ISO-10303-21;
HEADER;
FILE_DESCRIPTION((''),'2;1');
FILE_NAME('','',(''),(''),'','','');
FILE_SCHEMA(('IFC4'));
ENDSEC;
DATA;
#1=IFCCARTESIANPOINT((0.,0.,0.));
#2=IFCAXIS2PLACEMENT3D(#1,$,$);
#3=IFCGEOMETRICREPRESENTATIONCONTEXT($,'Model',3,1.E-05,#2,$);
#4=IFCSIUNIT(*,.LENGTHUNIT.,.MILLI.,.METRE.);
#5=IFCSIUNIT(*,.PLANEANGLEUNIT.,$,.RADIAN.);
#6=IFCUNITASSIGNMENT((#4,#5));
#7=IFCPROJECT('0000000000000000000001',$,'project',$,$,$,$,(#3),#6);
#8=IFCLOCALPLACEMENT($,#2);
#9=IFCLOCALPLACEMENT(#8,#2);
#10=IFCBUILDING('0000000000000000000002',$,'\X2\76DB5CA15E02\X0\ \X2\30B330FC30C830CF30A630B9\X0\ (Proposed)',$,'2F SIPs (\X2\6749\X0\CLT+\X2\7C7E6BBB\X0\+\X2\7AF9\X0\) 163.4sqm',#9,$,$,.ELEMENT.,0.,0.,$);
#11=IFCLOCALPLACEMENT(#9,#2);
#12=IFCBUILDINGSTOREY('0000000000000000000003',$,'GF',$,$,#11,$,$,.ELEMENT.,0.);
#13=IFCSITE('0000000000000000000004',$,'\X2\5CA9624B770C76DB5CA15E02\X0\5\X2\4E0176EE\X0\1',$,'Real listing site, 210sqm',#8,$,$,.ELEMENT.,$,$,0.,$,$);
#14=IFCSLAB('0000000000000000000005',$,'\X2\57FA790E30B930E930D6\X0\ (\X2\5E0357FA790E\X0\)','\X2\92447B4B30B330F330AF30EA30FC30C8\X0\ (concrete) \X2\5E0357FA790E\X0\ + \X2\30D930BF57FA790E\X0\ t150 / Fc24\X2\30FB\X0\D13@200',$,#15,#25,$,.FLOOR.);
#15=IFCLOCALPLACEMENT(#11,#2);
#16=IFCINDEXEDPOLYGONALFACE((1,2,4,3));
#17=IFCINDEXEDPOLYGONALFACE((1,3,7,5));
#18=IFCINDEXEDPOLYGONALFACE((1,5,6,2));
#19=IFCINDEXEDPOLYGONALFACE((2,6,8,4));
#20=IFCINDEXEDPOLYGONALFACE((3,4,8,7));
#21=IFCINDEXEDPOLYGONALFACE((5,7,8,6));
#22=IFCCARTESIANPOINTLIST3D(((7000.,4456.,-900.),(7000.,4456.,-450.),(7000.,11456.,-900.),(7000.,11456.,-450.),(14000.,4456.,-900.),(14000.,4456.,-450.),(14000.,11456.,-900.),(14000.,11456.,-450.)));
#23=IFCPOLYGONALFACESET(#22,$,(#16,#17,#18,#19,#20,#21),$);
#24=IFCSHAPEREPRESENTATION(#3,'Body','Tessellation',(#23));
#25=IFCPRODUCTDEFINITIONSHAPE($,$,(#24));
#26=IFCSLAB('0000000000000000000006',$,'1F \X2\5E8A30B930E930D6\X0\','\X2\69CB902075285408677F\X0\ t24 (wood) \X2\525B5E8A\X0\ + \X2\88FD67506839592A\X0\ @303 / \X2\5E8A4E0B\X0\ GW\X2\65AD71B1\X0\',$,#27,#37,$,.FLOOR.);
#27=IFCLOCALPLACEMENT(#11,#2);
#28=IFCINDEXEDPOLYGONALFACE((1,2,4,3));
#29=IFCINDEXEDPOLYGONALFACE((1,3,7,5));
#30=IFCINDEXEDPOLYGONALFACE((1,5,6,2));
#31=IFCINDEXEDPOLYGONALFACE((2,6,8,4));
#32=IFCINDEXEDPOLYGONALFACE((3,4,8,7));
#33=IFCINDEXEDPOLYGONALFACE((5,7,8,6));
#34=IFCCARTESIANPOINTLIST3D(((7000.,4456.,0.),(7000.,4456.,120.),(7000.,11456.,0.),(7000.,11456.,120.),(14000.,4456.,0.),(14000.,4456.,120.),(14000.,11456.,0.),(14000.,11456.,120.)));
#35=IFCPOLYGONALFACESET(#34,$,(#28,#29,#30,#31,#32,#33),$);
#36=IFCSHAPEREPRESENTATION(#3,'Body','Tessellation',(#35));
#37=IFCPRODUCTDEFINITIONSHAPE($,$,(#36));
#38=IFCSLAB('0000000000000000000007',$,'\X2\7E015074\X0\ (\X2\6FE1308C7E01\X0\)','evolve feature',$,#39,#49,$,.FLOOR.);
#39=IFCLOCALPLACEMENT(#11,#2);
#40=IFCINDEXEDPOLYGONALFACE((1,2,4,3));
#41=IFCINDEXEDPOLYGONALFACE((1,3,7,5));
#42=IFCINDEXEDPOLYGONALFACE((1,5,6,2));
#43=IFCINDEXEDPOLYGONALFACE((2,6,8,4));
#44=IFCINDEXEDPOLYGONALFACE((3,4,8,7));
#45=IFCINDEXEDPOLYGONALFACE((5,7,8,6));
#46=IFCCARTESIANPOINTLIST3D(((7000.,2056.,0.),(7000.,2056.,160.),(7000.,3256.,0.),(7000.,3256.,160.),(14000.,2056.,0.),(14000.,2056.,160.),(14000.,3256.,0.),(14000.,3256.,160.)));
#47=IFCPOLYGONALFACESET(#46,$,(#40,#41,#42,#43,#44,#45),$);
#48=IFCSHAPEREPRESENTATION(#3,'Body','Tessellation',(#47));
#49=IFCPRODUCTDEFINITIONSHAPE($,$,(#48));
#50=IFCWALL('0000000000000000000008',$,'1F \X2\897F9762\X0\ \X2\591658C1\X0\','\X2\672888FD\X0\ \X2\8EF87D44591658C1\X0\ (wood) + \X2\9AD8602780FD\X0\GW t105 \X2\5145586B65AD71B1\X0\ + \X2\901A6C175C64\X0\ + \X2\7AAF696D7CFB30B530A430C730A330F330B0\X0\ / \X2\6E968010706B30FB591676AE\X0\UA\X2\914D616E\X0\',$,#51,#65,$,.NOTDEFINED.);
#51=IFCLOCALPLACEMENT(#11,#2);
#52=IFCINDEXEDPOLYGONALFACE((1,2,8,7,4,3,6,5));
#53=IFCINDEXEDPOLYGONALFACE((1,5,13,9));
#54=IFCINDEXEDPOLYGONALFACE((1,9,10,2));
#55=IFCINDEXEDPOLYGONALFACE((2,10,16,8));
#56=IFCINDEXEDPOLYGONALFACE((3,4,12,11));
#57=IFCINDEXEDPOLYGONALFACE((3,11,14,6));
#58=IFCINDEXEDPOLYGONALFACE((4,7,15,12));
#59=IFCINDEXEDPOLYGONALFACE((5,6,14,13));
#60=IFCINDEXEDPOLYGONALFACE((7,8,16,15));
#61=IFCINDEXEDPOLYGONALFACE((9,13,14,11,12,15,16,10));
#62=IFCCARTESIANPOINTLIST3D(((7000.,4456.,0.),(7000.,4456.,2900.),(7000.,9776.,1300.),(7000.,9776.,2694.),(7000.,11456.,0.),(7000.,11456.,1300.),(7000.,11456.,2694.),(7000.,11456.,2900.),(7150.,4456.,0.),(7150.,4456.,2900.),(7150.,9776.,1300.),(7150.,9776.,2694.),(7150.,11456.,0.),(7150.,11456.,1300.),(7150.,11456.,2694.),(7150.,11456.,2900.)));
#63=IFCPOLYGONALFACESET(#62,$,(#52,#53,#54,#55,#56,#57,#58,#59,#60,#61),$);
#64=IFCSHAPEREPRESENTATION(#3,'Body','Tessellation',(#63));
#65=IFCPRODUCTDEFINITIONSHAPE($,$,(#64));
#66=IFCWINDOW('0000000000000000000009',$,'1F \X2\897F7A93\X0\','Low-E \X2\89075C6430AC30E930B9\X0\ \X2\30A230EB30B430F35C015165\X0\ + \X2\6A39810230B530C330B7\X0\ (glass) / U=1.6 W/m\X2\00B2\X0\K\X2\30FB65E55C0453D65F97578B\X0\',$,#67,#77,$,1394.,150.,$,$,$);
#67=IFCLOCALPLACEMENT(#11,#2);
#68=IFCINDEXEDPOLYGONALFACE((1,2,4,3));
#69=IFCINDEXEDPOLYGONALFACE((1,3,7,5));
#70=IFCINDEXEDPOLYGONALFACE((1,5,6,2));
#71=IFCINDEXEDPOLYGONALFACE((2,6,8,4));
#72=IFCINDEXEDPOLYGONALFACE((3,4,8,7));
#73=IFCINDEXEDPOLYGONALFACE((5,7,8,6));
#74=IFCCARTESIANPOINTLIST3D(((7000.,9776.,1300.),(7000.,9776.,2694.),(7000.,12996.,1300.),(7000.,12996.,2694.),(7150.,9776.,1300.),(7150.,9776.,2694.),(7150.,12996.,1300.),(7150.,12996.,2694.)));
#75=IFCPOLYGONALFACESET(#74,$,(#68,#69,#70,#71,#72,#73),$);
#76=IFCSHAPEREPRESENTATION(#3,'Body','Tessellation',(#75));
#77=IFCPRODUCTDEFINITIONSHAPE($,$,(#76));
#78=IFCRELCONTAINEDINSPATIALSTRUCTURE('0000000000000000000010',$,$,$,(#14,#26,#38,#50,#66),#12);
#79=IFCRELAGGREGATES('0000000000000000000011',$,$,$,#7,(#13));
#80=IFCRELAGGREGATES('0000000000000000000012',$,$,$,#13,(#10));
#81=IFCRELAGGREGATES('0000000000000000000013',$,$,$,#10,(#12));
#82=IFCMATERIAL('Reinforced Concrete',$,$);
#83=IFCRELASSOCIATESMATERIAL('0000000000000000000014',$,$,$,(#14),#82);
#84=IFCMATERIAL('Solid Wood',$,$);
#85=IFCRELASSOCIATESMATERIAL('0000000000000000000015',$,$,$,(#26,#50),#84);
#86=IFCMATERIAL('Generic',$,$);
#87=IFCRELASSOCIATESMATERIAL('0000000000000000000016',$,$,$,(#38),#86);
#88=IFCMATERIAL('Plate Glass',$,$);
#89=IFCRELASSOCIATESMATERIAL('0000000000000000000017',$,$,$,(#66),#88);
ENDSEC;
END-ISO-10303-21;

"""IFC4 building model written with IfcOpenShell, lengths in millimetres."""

from ifc_helpers import new_model, si_unit, frame, frame_2d, origin, place, context, project, spatial, rectangle, extrude, material, element, fill, save


model = new_model("IFC4")

# Units and contexts
model_context = context("Model", 3, precision=1e-05, world=origin())
ifc_project = project(units=[si_unit("LENGTHUNIT", "METRE", prefix="MILLI"), si_unit("PLANEANGLEUNIT", "RADIAN")], contexts=[model_context])

# Site, building, storey
site_placement = place(None, origin())
site = spatial("IfcSite", under=ifc_project, at=site_placement, Name="岩手県盛岡市5丁目1", ObjectType="Real listing site, 210sqm", CompositionType="ELEMENT", RefElevation=0.0)
building_placement = place(site_placement, origin())
building = spatial("IfcBuilding", under=site, at=building_placement, Name="盛岡市 コートハウス (Proposed)", ObjectType="2F SIPs (杉CLT+籾殻+竹) 163.4sqm", CompositionType="ELEMENT", ElevationOfRefHeight=0.0, ElevationOfTerrain=0.0)
storey_placement = place(building_placement, origin())
storey = spatial("IfcBuildingStorey", under=building, at=storey_placement, Name="GF", CompositionType="ELEMENT", Elevation=0.0)

# Slabs
ifc_material_1 = material(Name="Reinforced Concrete")
slab_1_placement = place(storey_placement, frame((3500.0, 2228.0, -450.0)))
element("IfcSlab", 1, at=slab_1_placement, inside=storey, material=ifc_material_1, Name="基礎スラブ (布基礎)", Description="鉄筋コンクリート (concrete) 布基礎 + ベタ基礎 t150 / Fc24・D13@200", PredefinedType="FLOOR", context=model_context, shape_type="SweptSolid", body=[
    extrude(rectangle(XDim=7000.0, YDim=7000.0, at=frame_2d((3500.0, 3500.0))), frame((3500.0, 2228.0, -450.0)), (0.0, 0.0, 1.0), 450.0),
])
ifc_material_2 = material(Name="Solid Wood")
slab_2_placement = place(storey_placement, frame((3500.0, 2228.0, 0.0)))
element("IfcSlab", 2, at=slab_2_placement, inside=storey, material=ifc_material_2, Name="1F 床スラブ", Description="構造用合板 t24 (wood) 剛床 + 製材根太 @303 / 床下 GW断熱", PredefinedType="FLOOR", context=model_context, shape_type="SweptSolid", body=[
    extrude(rectangle(XDim=7000.0, YDim=7000.0, at=frame_2d((3500.0, 3500.0))), frame((3500.0, 2228.0, 0.0)), (0.0, 0.0, 1.0), 120.0),
])
ifc_material_3 = material(Name="Generic")
slab_3_placement = place(storey_placement, frame((3500.0, 1028.0, 0.0)))
element("IfcSlab", 3, at=slab_3_placement, inside=storey, material=ifc_material_3, Name="縁側 (濡れ縁)", Description="evolve feature", PredefinedType="FLOOR", context=model_context, shape_type="SweptSolid", body=[
    extrude(rectangle(XDim=7000.0, YDim=1200.0, at=frame_2d((3500.0, 600.0))), frame((3500.0, 1028.0, 0.0)), (0.0, 0.0, 1.0), 160.0),
])

# Shared definitions
ifc_material_4 = material(Name="Plate Glass")

# Wall, opening, window
wall_1_placement = place(storey_placement, frame((3500.0, 2228.0, 0.0)))
wall_1 = element("IfcWall", 4, at=wall_1_placement, inside=storey, material=ifc_material_2, Name="1F 西面 外壁", Description="木製 軸組外壁 (wood) + 高性能GW t105 充填断熱 + 通気層 + 窯業系サイディング / 準耐火・外皮UA配慮", PredefinedType="NOTDEFINED", context=model_context, shape_type="SweptSolid", body=[
    extrude(rectangle(XDim=150.0, YDim=7000.0, at=frame_2d((75.0, 3500.0))), frame((3500.0, 2228.0, 0.0)), (0.0, 0.0, 1.0), 2900.0),
])
opening_1_placement = place(storey_placement, frame((3500.0, 4888.0, 650.0)))
opening_1 = element("IfcOpeningElement", 5, at=opening_1_placement, cuts=wall_1, PredefinedType="NOTDEFINED", context=model_context, shape_type="SweptSolid", body=[
    extrude(rectangle(XDim=150.0, YDim=3220.0, at=frame_2d((75.0, 1610.0))), frame((3500.0, 4888.0, 650.0)), (0.0, 0.0, 1.0), 1394.0),
])
window_1_placement = place(storey_placement, frame((3500.0, 4888.0, 650.0)))
window_1 = element("IfcWindow", 6, at=window_1_placement, inside=storey, material=ifc_material_4, Name="1F 西窓", Description="Low-E 複層ガラス アルゴン封入 + 樹脂サッシ (glass) / U=1.6 W/m²K・日射取得型", OverallHeight=1394.0, OverallWidth=150.0, context=model_context, shape_type="SweptSolid", body=[
    extrude(rectangle(XDim=150.0, YDim=3220.0, at=frame_2d((75.0, 1610.0))), frame((3500.0, 4888.0, 650.0)), (0.0, 0.0, 1.0), 1394.0),
])
fill(opening_1, window_1)

save(model, "model.ifc")
